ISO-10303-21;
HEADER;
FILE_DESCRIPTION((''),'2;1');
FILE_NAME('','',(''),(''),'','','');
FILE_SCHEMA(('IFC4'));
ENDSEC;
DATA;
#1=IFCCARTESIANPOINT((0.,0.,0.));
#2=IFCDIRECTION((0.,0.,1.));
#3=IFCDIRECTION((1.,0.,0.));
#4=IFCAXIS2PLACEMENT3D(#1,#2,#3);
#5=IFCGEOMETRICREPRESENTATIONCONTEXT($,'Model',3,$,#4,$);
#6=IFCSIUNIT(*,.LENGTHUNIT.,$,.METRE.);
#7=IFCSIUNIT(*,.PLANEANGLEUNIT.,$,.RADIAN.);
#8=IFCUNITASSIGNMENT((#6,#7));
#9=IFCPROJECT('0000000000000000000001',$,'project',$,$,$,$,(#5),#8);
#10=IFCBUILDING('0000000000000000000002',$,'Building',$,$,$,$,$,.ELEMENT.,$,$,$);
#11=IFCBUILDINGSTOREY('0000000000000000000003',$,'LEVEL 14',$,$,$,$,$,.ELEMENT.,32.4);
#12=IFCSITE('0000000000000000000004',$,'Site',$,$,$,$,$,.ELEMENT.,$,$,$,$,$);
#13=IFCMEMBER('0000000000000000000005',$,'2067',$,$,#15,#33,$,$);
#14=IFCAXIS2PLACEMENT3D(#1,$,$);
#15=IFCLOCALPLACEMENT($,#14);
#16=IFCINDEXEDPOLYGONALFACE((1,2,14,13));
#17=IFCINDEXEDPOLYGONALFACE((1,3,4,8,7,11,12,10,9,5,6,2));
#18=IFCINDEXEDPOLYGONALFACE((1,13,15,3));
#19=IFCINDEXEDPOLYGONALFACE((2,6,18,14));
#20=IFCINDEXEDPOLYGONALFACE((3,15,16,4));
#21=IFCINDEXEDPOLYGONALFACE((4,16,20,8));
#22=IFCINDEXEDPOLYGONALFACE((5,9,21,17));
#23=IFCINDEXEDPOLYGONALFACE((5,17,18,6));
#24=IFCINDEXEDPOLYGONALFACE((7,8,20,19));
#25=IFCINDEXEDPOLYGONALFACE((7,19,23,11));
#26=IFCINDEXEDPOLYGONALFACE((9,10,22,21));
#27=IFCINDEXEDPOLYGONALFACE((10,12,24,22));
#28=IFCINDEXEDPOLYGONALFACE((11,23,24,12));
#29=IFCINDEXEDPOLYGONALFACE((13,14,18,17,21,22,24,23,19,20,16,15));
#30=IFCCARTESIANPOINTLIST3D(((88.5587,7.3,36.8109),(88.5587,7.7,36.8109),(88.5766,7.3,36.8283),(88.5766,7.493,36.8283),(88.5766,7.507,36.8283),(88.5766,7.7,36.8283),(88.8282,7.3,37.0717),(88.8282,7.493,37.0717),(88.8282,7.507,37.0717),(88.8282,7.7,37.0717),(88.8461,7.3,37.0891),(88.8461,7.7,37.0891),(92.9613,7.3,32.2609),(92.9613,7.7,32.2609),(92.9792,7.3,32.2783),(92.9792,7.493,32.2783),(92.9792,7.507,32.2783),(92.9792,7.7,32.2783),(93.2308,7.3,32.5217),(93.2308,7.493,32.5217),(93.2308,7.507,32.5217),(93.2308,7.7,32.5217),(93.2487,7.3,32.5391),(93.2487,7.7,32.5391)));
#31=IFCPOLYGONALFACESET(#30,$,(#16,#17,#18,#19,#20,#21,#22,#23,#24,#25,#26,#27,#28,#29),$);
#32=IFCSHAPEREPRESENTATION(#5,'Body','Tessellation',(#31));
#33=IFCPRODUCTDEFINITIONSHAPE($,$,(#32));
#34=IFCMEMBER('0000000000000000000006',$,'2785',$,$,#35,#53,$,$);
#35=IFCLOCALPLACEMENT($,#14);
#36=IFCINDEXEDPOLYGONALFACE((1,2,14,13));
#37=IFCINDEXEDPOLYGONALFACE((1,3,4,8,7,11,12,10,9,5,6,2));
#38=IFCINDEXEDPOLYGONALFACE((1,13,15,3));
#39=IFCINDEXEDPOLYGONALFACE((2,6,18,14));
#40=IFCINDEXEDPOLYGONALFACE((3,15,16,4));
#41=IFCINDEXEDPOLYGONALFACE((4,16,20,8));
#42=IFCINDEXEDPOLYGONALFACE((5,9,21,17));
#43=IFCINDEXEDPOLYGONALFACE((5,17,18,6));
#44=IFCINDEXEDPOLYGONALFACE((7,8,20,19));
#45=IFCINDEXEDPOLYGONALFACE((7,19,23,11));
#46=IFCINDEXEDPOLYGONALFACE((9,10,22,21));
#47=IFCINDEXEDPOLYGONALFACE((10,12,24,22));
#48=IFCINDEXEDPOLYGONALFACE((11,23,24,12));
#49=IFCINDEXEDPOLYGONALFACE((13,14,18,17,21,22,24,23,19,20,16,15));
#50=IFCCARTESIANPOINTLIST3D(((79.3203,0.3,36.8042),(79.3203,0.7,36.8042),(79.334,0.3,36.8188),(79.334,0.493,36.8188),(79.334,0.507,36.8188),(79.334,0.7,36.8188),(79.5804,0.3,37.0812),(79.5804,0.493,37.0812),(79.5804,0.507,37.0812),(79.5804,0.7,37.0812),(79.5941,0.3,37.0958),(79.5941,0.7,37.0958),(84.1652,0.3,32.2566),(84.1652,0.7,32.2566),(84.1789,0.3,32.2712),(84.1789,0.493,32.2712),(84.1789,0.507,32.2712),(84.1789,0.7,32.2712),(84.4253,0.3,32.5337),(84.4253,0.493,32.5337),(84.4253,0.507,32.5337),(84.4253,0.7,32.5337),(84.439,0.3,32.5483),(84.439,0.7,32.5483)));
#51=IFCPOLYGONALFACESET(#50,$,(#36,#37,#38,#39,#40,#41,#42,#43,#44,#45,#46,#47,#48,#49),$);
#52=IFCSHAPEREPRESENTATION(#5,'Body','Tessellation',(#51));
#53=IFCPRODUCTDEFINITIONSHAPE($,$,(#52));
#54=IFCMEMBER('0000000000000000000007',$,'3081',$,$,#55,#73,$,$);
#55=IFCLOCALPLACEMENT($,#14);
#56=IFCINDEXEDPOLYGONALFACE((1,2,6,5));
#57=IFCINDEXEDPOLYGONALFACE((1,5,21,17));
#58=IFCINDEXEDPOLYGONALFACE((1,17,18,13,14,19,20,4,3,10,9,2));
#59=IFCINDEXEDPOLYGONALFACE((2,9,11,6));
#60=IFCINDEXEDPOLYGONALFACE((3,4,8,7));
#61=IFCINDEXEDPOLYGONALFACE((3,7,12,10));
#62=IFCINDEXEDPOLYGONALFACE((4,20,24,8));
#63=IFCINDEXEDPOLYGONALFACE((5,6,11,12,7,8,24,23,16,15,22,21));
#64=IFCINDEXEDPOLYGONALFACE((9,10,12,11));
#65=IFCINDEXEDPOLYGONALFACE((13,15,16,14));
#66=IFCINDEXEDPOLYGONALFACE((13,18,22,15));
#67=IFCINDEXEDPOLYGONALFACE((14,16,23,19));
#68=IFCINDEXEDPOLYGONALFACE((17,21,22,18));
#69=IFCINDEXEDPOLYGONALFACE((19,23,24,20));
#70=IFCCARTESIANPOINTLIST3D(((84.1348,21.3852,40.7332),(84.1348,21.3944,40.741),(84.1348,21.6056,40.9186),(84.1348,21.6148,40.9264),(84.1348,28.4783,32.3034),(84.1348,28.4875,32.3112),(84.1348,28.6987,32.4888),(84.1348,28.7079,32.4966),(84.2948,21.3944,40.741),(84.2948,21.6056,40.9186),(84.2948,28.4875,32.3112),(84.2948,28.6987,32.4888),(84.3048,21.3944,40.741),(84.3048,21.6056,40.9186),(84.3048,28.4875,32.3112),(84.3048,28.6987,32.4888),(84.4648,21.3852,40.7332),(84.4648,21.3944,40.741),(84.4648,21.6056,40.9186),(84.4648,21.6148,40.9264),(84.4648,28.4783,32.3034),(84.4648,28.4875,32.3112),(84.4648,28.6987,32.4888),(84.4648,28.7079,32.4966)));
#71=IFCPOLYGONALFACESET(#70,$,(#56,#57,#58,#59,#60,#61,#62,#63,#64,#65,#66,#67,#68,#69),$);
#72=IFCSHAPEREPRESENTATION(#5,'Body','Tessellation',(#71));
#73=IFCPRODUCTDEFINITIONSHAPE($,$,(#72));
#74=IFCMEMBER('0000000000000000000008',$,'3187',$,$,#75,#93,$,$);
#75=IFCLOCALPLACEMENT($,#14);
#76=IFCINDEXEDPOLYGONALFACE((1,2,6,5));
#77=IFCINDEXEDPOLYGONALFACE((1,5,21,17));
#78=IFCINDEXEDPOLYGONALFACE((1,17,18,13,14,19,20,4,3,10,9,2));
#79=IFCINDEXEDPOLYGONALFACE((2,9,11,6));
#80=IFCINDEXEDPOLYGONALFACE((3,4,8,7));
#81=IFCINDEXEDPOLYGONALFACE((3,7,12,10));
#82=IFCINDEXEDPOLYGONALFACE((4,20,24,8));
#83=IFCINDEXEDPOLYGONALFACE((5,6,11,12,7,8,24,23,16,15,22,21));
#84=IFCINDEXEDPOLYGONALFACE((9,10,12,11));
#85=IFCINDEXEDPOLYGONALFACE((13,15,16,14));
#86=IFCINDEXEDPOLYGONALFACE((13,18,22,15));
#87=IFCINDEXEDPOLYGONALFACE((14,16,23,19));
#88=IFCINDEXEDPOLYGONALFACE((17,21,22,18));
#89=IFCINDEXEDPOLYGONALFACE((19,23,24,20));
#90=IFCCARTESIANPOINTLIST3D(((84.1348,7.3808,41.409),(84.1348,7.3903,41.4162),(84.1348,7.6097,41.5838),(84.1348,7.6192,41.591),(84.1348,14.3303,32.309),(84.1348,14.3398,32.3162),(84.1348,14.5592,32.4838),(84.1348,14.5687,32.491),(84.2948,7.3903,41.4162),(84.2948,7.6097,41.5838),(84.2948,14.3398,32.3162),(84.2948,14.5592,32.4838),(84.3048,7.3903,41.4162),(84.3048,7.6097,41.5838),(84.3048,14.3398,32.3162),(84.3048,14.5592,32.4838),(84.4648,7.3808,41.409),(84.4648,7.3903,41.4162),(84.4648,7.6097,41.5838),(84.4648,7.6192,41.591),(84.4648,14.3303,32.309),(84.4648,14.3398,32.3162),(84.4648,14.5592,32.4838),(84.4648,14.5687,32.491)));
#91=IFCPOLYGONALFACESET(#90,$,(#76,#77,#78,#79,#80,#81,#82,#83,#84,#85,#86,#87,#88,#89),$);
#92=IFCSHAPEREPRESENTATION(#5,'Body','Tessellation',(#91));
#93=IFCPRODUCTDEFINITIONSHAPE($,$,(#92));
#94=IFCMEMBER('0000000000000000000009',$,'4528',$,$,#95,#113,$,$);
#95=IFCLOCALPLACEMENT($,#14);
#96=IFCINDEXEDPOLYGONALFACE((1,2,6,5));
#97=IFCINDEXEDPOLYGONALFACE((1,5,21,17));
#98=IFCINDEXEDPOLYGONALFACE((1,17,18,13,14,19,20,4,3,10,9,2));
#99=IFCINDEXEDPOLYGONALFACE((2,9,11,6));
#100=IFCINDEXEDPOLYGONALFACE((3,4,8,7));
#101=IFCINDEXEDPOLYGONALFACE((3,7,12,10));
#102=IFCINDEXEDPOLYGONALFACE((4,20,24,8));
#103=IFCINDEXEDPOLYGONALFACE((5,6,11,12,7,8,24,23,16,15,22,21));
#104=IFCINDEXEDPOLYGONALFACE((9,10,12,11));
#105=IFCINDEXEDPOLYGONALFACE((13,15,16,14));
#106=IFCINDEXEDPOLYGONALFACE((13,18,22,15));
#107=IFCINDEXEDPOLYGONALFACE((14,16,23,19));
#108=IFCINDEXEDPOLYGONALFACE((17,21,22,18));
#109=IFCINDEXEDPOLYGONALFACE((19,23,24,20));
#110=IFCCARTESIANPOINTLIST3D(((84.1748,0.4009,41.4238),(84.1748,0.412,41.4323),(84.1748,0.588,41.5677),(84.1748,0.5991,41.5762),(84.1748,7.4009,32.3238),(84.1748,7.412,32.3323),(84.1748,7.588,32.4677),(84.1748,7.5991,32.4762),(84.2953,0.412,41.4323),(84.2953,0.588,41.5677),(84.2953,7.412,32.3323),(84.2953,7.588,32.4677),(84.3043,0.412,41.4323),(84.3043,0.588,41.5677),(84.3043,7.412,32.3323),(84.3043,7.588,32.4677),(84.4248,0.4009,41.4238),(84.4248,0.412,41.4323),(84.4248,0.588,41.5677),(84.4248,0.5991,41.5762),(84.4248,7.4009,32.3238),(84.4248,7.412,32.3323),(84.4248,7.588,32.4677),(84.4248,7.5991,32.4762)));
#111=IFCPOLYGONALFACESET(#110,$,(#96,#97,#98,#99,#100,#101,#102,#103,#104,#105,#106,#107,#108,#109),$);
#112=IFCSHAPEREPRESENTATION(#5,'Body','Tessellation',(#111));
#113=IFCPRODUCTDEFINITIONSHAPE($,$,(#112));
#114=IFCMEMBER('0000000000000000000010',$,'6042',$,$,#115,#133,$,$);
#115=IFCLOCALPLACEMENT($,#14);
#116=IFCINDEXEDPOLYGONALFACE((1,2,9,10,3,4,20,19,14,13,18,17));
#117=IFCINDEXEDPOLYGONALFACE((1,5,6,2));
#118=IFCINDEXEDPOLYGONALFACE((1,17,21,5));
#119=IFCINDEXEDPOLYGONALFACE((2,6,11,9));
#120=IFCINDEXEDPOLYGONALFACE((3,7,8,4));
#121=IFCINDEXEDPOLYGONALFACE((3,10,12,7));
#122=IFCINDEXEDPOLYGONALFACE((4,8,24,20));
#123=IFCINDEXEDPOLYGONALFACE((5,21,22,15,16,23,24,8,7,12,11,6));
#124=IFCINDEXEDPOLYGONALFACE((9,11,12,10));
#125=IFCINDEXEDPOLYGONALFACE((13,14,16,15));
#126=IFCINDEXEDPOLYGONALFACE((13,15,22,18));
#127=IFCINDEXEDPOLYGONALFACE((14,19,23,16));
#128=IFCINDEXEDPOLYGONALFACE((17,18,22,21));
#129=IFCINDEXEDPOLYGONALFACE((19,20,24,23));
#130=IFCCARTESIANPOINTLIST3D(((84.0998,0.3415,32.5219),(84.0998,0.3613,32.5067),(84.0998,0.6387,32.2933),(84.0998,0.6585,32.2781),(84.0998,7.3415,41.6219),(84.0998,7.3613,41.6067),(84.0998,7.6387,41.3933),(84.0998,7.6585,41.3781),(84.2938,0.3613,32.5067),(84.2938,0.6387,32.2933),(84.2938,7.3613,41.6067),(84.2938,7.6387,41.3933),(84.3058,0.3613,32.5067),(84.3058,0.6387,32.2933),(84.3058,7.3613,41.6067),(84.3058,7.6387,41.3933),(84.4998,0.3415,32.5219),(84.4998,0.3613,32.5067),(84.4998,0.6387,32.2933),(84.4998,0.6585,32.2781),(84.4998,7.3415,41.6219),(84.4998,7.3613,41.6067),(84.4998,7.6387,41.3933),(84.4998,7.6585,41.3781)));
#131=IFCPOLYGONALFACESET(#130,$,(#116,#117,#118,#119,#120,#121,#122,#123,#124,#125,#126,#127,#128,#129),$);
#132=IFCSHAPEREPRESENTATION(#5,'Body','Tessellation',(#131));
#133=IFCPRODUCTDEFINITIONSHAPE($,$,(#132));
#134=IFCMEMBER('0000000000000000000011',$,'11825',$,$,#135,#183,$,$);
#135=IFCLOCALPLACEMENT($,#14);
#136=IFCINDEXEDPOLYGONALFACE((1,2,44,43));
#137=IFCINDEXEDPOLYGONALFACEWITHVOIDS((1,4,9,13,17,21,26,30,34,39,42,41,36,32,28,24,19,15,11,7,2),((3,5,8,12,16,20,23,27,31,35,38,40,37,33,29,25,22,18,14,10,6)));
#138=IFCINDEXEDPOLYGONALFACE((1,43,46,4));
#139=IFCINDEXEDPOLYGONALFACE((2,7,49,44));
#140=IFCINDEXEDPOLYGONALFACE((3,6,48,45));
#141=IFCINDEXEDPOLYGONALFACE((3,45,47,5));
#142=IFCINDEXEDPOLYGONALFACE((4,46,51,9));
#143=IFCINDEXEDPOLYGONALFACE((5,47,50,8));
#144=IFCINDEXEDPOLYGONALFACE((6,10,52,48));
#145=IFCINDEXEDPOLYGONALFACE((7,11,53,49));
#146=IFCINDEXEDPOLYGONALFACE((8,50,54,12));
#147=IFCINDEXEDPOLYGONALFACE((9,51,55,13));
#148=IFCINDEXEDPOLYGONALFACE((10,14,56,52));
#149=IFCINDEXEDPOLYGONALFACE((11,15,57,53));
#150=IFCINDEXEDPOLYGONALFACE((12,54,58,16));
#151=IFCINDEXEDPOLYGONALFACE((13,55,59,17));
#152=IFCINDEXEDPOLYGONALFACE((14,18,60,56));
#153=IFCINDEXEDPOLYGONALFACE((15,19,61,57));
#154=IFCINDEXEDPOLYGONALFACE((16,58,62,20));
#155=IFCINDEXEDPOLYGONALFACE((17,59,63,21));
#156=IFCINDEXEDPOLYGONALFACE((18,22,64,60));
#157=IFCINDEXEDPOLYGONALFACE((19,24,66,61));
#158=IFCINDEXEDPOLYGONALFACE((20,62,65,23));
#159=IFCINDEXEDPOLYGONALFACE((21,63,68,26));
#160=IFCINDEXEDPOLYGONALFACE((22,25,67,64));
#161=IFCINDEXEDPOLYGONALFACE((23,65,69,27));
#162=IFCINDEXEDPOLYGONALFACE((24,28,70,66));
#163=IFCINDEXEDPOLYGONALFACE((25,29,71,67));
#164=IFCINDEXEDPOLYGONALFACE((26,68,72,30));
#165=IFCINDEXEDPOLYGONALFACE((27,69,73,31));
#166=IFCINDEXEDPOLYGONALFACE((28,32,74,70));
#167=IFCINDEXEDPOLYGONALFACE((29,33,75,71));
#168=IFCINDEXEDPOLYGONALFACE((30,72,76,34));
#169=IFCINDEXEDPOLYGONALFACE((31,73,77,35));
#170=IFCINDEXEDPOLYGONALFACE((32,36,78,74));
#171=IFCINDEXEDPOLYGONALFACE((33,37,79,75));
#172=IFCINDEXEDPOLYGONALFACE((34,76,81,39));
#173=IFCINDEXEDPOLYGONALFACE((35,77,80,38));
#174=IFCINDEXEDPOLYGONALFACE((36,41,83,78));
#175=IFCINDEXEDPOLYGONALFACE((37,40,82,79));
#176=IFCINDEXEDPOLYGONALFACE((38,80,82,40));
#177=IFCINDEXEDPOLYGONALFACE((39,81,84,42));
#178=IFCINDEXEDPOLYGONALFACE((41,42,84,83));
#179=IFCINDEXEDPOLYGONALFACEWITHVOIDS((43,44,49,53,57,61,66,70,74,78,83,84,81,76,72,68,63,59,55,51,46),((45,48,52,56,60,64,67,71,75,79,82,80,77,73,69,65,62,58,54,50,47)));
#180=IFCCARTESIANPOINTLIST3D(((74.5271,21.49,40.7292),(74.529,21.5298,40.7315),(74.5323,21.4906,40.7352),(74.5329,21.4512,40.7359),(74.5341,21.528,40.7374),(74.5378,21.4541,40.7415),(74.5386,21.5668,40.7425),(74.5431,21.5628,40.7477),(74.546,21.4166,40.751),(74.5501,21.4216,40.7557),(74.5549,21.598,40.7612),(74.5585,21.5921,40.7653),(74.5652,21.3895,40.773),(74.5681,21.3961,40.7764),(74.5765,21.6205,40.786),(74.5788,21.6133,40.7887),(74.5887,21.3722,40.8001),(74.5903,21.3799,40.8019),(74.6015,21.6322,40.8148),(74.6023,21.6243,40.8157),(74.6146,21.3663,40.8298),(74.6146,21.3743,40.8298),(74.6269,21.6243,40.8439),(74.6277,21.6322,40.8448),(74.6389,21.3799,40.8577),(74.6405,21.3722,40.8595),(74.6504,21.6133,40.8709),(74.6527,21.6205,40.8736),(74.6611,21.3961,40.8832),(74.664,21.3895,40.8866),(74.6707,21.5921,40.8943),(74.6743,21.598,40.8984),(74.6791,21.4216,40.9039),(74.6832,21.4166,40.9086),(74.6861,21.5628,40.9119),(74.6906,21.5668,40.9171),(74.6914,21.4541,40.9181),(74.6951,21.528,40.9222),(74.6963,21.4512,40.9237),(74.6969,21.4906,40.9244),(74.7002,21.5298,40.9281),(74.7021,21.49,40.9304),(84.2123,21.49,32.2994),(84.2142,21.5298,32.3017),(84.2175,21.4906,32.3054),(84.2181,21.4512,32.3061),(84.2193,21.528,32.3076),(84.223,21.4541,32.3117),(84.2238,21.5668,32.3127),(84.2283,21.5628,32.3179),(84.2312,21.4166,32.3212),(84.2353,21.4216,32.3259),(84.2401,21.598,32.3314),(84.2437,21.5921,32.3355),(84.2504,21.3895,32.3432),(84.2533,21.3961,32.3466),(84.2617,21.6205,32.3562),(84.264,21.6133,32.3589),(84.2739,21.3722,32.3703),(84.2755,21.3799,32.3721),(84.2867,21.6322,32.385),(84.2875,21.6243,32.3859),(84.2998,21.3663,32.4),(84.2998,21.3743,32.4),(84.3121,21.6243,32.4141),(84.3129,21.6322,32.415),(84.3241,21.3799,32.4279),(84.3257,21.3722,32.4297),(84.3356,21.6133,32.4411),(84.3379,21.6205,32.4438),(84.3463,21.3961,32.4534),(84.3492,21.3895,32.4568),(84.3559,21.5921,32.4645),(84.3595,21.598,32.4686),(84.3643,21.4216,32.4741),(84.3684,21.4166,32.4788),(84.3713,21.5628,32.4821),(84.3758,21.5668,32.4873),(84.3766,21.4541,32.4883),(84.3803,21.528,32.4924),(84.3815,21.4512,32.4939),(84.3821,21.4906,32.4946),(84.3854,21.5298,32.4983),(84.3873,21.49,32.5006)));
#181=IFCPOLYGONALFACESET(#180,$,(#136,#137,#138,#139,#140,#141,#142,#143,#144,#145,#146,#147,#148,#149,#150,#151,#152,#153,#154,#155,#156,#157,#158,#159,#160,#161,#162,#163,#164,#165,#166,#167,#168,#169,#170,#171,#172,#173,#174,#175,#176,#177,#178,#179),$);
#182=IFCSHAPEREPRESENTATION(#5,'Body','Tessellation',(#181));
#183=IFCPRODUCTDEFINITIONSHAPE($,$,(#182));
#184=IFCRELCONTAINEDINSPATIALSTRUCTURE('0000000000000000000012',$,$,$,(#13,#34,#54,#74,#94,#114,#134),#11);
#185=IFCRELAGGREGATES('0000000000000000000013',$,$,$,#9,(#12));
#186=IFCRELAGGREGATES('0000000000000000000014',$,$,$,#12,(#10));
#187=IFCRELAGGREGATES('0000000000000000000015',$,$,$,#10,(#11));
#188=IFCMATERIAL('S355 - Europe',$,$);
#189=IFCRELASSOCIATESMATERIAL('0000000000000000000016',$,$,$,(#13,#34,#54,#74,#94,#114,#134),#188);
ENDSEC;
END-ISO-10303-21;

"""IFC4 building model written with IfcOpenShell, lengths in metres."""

from ifc_helpers import new_model, si_unit, frame, origin_with_axes, origin_2d_with_axis, place, context, project, spatial, hollow_circle, i_section, extrude, material, material_profile, profile_set, profile_usage, element, save


model = new_model("IFC4")

# Units and contexts
model_context = context("Model", 3, world=origin_with_axes())
ifc_project = project(units=[si_unit("LENGTHUNIT", "METRE"), si_unit("PLANEANGLEUNIT", "RADIAN")], contexts=[model_context])

# Site, building, storey
site = spatial("IfcSite", under=ifc_project, Name="Site", CompositionType="ELEMENT")
building = spatial("IfcBuilding", under=site, Name="Building", CompositionType="ELEMENT")
storey = spatial("IfcBuildingStorey", under=building, Name="LEVEL 14", CompositionType="ELEMENT", Elevation=32.4)

# Shared definitions
ifc_material = material(Name="S355 - Europe")

# Members
ifc_material_profile_1 = material_profile(ifc_material, i_section(OverallWidth=0.4, OverallDepth=0.4, WebThickness=0.014, FlangeThickness=0.025, at=origin_2d_with_axis()))
ifc_profile_set_1 = profile_set([ifc_material_profile_1])
ifc_profile_usage_1 = profile_usage(ifc_profile_set_1, cardinal=10)
member_1_placement = place(None, frame((88.7024, 7.5, 36.95), z_axis=(0.69537, 0.0, -0.718652), x_axis=(0.0, 1.0, 0.0)))
element("IfcMember", 1, at=member_1_placement, inside=storey, material=ifc_profile_usage_1, Name="2067", context=model_context, shape_type="SweptSolid", body=[
    extrude(i_section(OverallWidth=0.4, OverallDepth=0.4, WebThickness=0.014, FlangeThickness=0.025, at=origin_2d_with_axis()), origin_with_axes(), (0.0, 0.0, 1.0), 6.3313),
])
ifc_material_profile_2 = material_profile(ifc_material, i_section(OverallWidth=0.4, OverallDepth=0.4, WebThickness=0.014, FlangeThickness=0.02, at=origin_2d_with_axis()))
ifc_profile_set_2 = profile_set([ifc_material_profile_2])
ifc_profile_usage_2 = profile_usage(ifc_profile_set_2, cardinal=10)
member_2_placement = place(None, frame((79.4572, 0.5, 36.95), z_axis=(0.729127, 0.0, -0.684379), x_axis=(0.0, 1.0, 0.0)))
element("IfcMember", 2, at=member_2_placement, inside=storey, material=ifc_profile_usage_2, Name="2785", context=model_context, shape_type="SweptSolid", body=[
    extrude(i_section(OverallWidth=0.4, OverallDepth=0.4, WebThickness=0.014, FlangeThickness=0.02, at=origin_2d_with_axis()), origin_with_axes(), (0.0, 0.0, 1.0), 6.6448),
])
ifc_material_profile_3 = material_profile(ifc_material, i_section(OverallWidth=0.33, OverallDepth=0.3, WebThickness=0.01, FlangeThickness=0.012, at=origin_2d_with_axis()))
ifc_profile_set_3 = profile_set([ifc_material_profile_3])
ifc_profile_usage_3 = profile_usage(ifc_profile_set_3, cardinal=10)
member_3_placement = place(None, frame((84.2998, 21.5, 40.8298), z_axis=(0.0, 0.643834, -0.765165), x_axis=(-1.0, 0.0, 0.0)))
element("IfcMember", 3, at=member_3_placement, inside=storey, material=ifc_profile_usage_3, Name="3081", context=model_context, shape_type="SweptSolid", body=[
    extrude(i_section(OverallWidth=0.33, OverallDepth=0.3, WebThickness=0.01, FlangeThickness=0.012, at=origin_2d_with_axis()), origin_with_axes(), (0.0, 0.0, 1.0), 11.017),
])
ifc_material_profile_4 = material_profile(ifc_material, i_section(OverallWidth=0.33, OverallDepth=0.3, WebThickness=0.01, FlangeThickness=0.012, at=origin_2d_with_axis()))
ifc_profile_set_4 = profile_set([ifc_material_profile_4])
ifc_profile_usage_4 = profile_usage(ifc_profile_set_4, cardinal=10)
member_4_placement = place(None, frame((84.2998, 7.5, 41.5), z_axis=(0.0, 0.606936, -0.794751), x_axis=(-1.0, 0.0, 0.0)))
element("IfcMember", 4, at=member_4_placement, inside=storey, material=ifc_profile_usage_4, Name="3187", context=model_context, shape_type="SweptSolid", body=[
    extrude(i_section(OverallWidth=0.33, OverallDepth=0.3, WebThickness=0.01, FlangeThickness=0.012, at=origin_2d_with_axis()), origin_with_axes(), (0.0, 0.0, 1.0), 11.4501),
])
ifc_material_profile_5 = material_profile(ifc_material, i_section(OverallWidth=0.25, OverallDepth=0.25, WebThickness=0.009, FlangeThickness=0.014, at=origin_2d_with_axis()))
ifc_profile_set_5 = profile_set([ifc_material_profile_5])
ifc_profile_usage_5 = profile_usage(ifc_profile_set_5, cardinal=10)
member_5_placement = place(None, frame((84.2998, 7.5, 32.4), z_axis=(0.0, -0.609711, 0.792624), x_axis=(1.0, 0.0, 0.0)))
element("IfcMember", 5, at=member_5_placement, inside=storey, material=ifc_profile_usage_5, Name="4528", context=model_context, shape_type="SweptSolid", body=[
    extrude(i_section(OverallWidth=0.25, OverallDepth=0.25, WebThickness=0.009, FlangeThickness=0.014, at=origin_2d_with_axis()), origin_with_axes(), (0.0, 0.0, 1.0), 11.4809),
])
ifc_material_profile_6 = material_profile(ifc_material, i_section(OverallWidth=0.4, OverallDepth=0.4, WebThickness=0.012, FlangeThickness=0.025, at=origin_2d_with_axis()))
ifc_profile_set_6 = profile_set([ifc_material_profile_6])
ifc_profile_usage_6 = profile_usage(ifc_profile_set_6, cardinal=10)
member_6_placement = place(None, frame((84.2998, 7.5, 41.5), z_axis=(0.0, -0.609711, -0.792624), x_axis=(1.0, 0.0, 0.0)))
element("IfcMember", 6, at=member_6_placement, inside=storey, material=ifc_profile_usage_6, Name="6042", context=model_context, shape_type="SweptSolid", body=[
    extrude(i_section(OverallWidth=0.4, OverallDepth=0.4, WebThickness=0.012, FlangeThickness=0.025, at=origin_2d_with_axis()), origin_with_axes(), (0.0, 0.0, 1.0), 11.4809),
])
ifc_material_profile_7 = material_profile(ifc_material, hollow_circle(Radius=0.1337, WallThickness=0.008, at=origin_2d_with_axis()))
ifc_profile_set_7 = profile_set([ifc_material_profile_7])
ifc_profile_usage_7 = profile_usage(ifc_profile_set_7, cardinal=10)
member_7_placement = place(None, frame((84.2998, 21.5, 32.4), z_axis=(-0.754301, 0.0, 0.656528), x_axis=(0.0, -1.0, 0.0)))
element("IfcMember", 7, at=member_7_placement, inside=storey, material=ifc_profile_usage_7, Name="11825", context=model_context, shape_type="SweptSolid", body=[
    extrude(hollow_circle(Radius=0.1337, WallThickness=0.008, at=origin_2d_with_axis()), origin_with_axes(), (0.0, 0.0, 1.0), 12.84),
])

save(model, "model.ifc")
